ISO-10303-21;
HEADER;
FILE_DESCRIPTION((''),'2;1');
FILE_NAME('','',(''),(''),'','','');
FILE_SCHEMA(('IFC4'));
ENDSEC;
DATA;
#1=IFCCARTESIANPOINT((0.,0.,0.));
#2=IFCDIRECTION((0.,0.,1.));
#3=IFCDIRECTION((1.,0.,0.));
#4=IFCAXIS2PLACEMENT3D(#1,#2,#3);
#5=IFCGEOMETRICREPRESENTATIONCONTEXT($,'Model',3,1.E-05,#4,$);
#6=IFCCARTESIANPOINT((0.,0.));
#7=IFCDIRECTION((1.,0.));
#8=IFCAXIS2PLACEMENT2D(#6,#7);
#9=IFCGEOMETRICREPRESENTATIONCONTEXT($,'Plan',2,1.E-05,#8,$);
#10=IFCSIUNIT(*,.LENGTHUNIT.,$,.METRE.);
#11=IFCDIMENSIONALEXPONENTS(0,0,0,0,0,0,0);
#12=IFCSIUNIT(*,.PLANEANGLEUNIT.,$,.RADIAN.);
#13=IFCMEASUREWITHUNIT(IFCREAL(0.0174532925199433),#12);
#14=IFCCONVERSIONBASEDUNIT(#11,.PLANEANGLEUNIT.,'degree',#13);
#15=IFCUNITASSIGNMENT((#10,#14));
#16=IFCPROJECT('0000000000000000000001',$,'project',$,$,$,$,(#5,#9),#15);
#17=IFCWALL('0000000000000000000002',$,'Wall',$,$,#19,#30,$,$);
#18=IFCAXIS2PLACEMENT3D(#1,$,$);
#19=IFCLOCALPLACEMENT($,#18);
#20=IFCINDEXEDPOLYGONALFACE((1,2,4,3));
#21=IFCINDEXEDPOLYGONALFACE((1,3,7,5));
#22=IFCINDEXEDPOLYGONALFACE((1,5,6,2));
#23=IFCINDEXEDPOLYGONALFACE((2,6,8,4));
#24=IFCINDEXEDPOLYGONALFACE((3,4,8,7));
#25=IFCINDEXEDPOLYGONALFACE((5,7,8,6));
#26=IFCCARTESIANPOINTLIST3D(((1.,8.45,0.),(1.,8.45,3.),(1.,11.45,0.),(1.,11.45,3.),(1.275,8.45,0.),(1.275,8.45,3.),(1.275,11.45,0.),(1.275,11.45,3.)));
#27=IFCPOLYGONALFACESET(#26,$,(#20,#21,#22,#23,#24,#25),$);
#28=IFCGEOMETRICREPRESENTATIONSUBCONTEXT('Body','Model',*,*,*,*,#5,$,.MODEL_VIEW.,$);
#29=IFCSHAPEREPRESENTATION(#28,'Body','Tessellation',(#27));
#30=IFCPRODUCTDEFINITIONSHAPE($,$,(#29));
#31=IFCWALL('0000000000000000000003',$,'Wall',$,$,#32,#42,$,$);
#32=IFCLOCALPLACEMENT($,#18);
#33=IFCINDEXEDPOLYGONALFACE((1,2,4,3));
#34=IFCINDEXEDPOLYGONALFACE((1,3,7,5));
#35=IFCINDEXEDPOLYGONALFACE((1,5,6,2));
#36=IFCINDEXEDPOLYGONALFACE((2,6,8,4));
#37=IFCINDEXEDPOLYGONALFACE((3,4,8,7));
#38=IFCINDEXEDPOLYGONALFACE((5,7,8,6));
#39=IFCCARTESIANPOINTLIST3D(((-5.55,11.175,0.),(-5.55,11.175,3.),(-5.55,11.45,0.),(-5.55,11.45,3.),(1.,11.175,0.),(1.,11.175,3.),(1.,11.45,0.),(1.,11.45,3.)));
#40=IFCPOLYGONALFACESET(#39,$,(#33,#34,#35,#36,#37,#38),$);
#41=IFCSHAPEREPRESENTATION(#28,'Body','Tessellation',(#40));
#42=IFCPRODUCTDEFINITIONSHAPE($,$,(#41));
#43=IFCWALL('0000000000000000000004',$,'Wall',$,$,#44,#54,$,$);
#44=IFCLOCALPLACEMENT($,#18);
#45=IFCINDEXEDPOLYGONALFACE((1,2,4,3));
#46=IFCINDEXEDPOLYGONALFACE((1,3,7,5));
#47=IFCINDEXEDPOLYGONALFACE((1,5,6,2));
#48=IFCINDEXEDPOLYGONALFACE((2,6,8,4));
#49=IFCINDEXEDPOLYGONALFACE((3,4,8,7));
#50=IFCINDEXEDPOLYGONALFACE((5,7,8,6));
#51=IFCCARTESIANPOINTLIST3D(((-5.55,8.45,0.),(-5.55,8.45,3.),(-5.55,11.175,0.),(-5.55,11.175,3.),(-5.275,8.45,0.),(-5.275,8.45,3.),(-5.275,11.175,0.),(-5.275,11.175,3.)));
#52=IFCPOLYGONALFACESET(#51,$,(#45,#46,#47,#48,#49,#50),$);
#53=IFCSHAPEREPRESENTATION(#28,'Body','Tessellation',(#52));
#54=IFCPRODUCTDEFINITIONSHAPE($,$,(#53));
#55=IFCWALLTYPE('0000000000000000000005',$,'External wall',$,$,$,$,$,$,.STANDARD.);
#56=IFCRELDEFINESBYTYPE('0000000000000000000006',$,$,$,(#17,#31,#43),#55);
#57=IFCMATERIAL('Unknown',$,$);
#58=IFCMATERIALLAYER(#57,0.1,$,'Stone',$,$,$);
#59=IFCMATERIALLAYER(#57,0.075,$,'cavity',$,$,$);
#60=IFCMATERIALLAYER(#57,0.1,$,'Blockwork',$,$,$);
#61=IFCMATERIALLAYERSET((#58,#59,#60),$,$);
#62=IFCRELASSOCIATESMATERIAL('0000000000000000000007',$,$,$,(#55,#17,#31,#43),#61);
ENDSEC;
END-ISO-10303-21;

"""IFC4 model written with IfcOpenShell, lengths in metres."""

from ifc_helpers import new_model, entity, si_unit, converted_unit, frame, origin_with_axes, origin_2d_with_axis, place, context, subcontext, project, indexed_curve, outline, extrude, material, layer, layer_set, layer_usage, type_object, element, save


model = new_model("IFC4")

# Units and contexts
model_context = context("Model", 3, precision=1e-05, world=origin_with_axes())
plan_context = context("Plan", 2, precision=1e-05, world=origin_2d_with_axis())
body_context = subcontext(model_context, "Body", "Model", "MODEL_VIEW")
ifc_project = project(units=[si_unit("LENGTHUNIT", "METRE"), converted_unit("PLANEANGLEUNIT", "degree", entity("IfcReal", 0.0174532925199433), si_unit("PLANEANGLEUNIT", "RADIAN"), dimensions=[0, 0, 0, 0, 0, 0, 0])], contexts=[model_context, plan_context])

# Walls
ifc_material = material(Name="Unknown")
ifc_layer_1 = layer(ifc_material, 0.1, Name="Stone")
ifc_layer_2 = layer(ifc_material, 0.075, Name="cavity")
ifc_layer_3 = layer(ifc_material, 0.1, Name="Blockwork")
ifc_layer_set = layer_set([ifc_layer_1, ifc_layer_2, ifc_layer_3])
ifc_layer_usage_1 = layer_usage(ifc_layer_set, "AXIS2", "POSITIVE", 0.0)
wall_type = type_object("IfcWallType", Name="External wall", PredefinedType="STANDARD", material=ifc_layer_set)
wall_1_placement = place(None, frame((1.275, 8.45, 0.0), z_axis=(0.0, 0.0, 1.0), x_axis=(0.0, 1.0, 0.0)))
element("IfcWall", 1, at=wall_1_placement, type_object=wall_type, material=ifc_layer_usage_1, Name="Wall", context=body_context, shape_type="SweptSolid", body=[
    extrude(outline(indexed_curve([(0.0, 0.0), (0.0, 0.275), (3.0, 0.275), (3.0, 0.0), (0.0, 0.0)], self_intersect=False)), origin_with_axes(), (0.0, 0.0, 1.0), 3.0),
])
ifc_layer_usage_2 = layer_usage(ifc_layer_set, "AXIS2", "POSITIVE", 0.0)
wall_2_placement = place(None, frame((1.0, 11.45, 0.0), z_axis=(0.0, 0.0, 1.0), x_axis=(-1.0, 0.0, 0.0)))
element("IfcWall", 2, at=wall_2_placement, type_object=wall_type, material=ifc_layer_usage_2, Name="Wall", context=body_context, shape_type="SweptSolid", body=[
    extrude(outline(indexed_curve([(0.0, 0.0), (0.0, 0.275), (6.55, 0.275), (6.55, 0.0), (0.0, 0.0)], self_intersect=False)), origin_with_axes(), (0.0, 0.0, 1.0), 3.0),
])
ifc_layer_usage_3 = layer_usage(ifc_layer_set, "AXIS2", "POSITIVE", 0.0)
wall_3_placement = place(None, frame((-5.275, 8.45, 0.0), z_axis=(0.0, 0.0, 1.0), x_axis=(0.0, 1.0, 0.0)))
element("IfcWall", 3, at=wall_3_placement, type_object=wall_type, material=ifc_layer_usage_3, Name="Wall", context=body_context, shape_type="SweptSolid", body=[
    extrude(outline(indexed_curve([(0.0, 0.0), (0.0, 0.275), (2.725, 0.275), (2.725, 0.0), (0.0, 0.0)], self_intersect=False)), origin_with_axes(), (0.0, 0.0, 1.0), 3.0),
])

save(model, "model.ifc")
